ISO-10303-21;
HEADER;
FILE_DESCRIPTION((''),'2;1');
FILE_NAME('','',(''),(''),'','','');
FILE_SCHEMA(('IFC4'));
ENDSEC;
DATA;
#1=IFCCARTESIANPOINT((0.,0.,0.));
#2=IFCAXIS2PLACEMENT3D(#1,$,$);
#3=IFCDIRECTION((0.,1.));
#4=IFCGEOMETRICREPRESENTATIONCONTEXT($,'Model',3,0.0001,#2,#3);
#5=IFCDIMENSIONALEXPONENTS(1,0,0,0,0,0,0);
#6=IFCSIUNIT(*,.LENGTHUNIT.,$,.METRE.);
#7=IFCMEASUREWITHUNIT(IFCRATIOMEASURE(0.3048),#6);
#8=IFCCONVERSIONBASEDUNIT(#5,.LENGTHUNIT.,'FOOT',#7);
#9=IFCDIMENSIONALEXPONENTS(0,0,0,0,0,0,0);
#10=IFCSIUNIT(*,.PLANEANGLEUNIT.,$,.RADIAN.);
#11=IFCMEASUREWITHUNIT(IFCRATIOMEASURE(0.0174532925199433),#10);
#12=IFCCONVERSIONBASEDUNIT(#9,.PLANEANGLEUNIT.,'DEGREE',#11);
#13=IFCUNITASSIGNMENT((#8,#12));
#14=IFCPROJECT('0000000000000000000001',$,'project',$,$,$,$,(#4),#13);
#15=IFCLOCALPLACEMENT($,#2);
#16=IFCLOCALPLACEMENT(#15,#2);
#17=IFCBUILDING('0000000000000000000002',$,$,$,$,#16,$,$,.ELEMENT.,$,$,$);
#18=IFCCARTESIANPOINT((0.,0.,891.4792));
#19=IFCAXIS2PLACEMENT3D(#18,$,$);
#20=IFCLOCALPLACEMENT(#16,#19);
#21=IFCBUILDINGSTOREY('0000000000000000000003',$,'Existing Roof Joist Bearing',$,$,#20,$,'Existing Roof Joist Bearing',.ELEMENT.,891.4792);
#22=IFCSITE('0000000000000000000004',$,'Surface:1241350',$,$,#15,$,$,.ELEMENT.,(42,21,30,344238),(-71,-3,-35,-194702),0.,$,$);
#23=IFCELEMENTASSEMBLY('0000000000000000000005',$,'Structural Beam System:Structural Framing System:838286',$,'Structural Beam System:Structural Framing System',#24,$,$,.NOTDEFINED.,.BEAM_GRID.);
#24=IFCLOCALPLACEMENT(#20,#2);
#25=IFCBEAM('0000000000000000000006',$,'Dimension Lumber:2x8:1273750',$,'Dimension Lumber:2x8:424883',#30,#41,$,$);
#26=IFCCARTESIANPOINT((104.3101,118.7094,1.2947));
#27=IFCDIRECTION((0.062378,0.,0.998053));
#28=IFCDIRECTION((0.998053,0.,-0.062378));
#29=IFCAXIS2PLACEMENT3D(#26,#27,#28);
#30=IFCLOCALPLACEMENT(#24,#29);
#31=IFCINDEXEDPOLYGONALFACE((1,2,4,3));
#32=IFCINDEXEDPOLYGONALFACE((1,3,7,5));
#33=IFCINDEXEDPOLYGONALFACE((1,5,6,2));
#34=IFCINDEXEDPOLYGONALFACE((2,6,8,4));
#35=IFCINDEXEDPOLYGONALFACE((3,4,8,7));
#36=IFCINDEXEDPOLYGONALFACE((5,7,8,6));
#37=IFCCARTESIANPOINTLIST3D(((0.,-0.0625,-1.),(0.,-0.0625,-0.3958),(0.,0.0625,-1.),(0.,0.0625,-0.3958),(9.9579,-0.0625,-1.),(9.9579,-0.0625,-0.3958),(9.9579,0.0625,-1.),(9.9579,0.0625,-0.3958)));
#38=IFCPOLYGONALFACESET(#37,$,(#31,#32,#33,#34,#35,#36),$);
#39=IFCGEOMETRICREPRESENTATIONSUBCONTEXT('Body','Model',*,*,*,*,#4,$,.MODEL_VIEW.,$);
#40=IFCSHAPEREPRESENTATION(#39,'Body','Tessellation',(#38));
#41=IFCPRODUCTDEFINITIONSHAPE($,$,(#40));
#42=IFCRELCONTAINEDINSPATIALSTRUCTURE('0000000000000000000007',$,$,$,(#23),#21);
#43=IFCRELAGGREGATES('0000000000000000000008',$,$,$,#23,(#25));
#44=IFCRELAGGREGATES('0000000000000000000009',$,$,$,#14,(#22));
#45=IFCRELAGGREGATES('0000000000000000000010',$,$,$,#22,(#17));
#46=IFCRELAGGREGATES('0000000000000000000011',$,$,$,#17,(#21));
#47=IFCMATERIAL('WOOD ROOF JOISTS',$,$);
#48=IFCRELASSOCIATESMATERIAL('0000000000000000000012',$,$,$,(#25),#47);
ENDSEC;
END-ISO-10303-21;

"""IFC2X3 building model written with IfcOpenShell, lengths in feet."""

from ifc_helpers import new_model, entity, si_unit, converted_unit, direction, frame, frame_2d, origin, place, context, subcontext, project, spatial, rectangle, extrude, material, element, aggregate, save


model = new_model("IFC2X3")

# Units and contexts
model_context = context("Model", 3, precision=0.0001, world=origin(), true_north=direction((0.0, 1.0)))
body_context = subcontext(model_context, "Body", "Model", "MODEL_VIEW")
ifc_project = project(units=[converted_unit("LENGTHUNIT", "FOOT", entity("IfcRatioMeasure", 0.3048), si_unit("LENGTHUNIT", "METRE"), dimensions=[1, 0, 0, 0, 0, 0, 0]), converted_unit("PLANEANGLEUNIT", "DEGREE", entity("IfcRatioMeasure", 0.0174532925199433), si_unit("PLANEANGLEUNIT", "RADIAN"), dimensions=[0, 0, 0, 0, 0, 0, 0])], contexts=[model_context])

# Site, building, storey
site_placement = place(None, origin())
site = spatial("IfcSite", under=ifc_project, at=site_placement, Name="Surface:1241350", CompositionType="ELEMENT", RefLatitude=(42, 21, 30, 344238), RefLongitude=(-71, -3, -35, -194702), RefElevation=0.0)
building_placement = place(site_placement, origin())
building = spatial("IfcBuilding", under=site, at=building_placement, CompositionType="ELEMENT")
storey_placement = place(building_placement, frame((0.0, 0.0, 891.4792)))
storey = spatial("IfcBuildingStorey", under=building, at=storey_placement, Name="Existing Roof Joist Bearing", LongName="Existing Roof Joist Bearing", CompositionType="ELEMENT", Elevation=891.4792)

# Element assembly, beam
assembly_1_placement = place(storey_placement, origin())
assembly_1 = element("IfcElementAssembly", 1, at=assembly_1_placement, inside=storey, Name="Structural Beam System:Structural Framing System:838286", ObjectType="Structural Beam System:Structural Framing System", AssemblyPlace="NOTDEFINED", PredefinedType="BEAM_GRID")
ifc_material_1 = material(Name="WOOD ROOF JOISTS")
beam_1_placement = place(assembly_1_placement, frame((104.3101, 118.7094, 1.2947), z_axis=(0.062378, 0.0, 0.998053), x_axis=(0.998053, 0.0, -0.062378)))
beam_1 = element("IfcBeam", 2, at=beam_1_placement, material=ifc_material_1, Name="Dimension Lumber:2x8:1273750", ObjectType="Dimension Lumber:2x8:424883", context=body_context, shape_type="SweptSolid", body=[
    extrude(rectangle(XDim=0.6042, YDim=0.125, at=frame_2d((0.0, 0.0), x_axis=(1.0, 0.0))), frame((0.0, 0.0, -0.6979), z_axis=(1.0, 0.0, 0.0), x_axis=(0.0, 0.0, -1.0)), (0.0, 0.0, 1.0), 9.9579),
])
aggregate(assembly_1, [beam_1])

save(model, "model.ifc")
